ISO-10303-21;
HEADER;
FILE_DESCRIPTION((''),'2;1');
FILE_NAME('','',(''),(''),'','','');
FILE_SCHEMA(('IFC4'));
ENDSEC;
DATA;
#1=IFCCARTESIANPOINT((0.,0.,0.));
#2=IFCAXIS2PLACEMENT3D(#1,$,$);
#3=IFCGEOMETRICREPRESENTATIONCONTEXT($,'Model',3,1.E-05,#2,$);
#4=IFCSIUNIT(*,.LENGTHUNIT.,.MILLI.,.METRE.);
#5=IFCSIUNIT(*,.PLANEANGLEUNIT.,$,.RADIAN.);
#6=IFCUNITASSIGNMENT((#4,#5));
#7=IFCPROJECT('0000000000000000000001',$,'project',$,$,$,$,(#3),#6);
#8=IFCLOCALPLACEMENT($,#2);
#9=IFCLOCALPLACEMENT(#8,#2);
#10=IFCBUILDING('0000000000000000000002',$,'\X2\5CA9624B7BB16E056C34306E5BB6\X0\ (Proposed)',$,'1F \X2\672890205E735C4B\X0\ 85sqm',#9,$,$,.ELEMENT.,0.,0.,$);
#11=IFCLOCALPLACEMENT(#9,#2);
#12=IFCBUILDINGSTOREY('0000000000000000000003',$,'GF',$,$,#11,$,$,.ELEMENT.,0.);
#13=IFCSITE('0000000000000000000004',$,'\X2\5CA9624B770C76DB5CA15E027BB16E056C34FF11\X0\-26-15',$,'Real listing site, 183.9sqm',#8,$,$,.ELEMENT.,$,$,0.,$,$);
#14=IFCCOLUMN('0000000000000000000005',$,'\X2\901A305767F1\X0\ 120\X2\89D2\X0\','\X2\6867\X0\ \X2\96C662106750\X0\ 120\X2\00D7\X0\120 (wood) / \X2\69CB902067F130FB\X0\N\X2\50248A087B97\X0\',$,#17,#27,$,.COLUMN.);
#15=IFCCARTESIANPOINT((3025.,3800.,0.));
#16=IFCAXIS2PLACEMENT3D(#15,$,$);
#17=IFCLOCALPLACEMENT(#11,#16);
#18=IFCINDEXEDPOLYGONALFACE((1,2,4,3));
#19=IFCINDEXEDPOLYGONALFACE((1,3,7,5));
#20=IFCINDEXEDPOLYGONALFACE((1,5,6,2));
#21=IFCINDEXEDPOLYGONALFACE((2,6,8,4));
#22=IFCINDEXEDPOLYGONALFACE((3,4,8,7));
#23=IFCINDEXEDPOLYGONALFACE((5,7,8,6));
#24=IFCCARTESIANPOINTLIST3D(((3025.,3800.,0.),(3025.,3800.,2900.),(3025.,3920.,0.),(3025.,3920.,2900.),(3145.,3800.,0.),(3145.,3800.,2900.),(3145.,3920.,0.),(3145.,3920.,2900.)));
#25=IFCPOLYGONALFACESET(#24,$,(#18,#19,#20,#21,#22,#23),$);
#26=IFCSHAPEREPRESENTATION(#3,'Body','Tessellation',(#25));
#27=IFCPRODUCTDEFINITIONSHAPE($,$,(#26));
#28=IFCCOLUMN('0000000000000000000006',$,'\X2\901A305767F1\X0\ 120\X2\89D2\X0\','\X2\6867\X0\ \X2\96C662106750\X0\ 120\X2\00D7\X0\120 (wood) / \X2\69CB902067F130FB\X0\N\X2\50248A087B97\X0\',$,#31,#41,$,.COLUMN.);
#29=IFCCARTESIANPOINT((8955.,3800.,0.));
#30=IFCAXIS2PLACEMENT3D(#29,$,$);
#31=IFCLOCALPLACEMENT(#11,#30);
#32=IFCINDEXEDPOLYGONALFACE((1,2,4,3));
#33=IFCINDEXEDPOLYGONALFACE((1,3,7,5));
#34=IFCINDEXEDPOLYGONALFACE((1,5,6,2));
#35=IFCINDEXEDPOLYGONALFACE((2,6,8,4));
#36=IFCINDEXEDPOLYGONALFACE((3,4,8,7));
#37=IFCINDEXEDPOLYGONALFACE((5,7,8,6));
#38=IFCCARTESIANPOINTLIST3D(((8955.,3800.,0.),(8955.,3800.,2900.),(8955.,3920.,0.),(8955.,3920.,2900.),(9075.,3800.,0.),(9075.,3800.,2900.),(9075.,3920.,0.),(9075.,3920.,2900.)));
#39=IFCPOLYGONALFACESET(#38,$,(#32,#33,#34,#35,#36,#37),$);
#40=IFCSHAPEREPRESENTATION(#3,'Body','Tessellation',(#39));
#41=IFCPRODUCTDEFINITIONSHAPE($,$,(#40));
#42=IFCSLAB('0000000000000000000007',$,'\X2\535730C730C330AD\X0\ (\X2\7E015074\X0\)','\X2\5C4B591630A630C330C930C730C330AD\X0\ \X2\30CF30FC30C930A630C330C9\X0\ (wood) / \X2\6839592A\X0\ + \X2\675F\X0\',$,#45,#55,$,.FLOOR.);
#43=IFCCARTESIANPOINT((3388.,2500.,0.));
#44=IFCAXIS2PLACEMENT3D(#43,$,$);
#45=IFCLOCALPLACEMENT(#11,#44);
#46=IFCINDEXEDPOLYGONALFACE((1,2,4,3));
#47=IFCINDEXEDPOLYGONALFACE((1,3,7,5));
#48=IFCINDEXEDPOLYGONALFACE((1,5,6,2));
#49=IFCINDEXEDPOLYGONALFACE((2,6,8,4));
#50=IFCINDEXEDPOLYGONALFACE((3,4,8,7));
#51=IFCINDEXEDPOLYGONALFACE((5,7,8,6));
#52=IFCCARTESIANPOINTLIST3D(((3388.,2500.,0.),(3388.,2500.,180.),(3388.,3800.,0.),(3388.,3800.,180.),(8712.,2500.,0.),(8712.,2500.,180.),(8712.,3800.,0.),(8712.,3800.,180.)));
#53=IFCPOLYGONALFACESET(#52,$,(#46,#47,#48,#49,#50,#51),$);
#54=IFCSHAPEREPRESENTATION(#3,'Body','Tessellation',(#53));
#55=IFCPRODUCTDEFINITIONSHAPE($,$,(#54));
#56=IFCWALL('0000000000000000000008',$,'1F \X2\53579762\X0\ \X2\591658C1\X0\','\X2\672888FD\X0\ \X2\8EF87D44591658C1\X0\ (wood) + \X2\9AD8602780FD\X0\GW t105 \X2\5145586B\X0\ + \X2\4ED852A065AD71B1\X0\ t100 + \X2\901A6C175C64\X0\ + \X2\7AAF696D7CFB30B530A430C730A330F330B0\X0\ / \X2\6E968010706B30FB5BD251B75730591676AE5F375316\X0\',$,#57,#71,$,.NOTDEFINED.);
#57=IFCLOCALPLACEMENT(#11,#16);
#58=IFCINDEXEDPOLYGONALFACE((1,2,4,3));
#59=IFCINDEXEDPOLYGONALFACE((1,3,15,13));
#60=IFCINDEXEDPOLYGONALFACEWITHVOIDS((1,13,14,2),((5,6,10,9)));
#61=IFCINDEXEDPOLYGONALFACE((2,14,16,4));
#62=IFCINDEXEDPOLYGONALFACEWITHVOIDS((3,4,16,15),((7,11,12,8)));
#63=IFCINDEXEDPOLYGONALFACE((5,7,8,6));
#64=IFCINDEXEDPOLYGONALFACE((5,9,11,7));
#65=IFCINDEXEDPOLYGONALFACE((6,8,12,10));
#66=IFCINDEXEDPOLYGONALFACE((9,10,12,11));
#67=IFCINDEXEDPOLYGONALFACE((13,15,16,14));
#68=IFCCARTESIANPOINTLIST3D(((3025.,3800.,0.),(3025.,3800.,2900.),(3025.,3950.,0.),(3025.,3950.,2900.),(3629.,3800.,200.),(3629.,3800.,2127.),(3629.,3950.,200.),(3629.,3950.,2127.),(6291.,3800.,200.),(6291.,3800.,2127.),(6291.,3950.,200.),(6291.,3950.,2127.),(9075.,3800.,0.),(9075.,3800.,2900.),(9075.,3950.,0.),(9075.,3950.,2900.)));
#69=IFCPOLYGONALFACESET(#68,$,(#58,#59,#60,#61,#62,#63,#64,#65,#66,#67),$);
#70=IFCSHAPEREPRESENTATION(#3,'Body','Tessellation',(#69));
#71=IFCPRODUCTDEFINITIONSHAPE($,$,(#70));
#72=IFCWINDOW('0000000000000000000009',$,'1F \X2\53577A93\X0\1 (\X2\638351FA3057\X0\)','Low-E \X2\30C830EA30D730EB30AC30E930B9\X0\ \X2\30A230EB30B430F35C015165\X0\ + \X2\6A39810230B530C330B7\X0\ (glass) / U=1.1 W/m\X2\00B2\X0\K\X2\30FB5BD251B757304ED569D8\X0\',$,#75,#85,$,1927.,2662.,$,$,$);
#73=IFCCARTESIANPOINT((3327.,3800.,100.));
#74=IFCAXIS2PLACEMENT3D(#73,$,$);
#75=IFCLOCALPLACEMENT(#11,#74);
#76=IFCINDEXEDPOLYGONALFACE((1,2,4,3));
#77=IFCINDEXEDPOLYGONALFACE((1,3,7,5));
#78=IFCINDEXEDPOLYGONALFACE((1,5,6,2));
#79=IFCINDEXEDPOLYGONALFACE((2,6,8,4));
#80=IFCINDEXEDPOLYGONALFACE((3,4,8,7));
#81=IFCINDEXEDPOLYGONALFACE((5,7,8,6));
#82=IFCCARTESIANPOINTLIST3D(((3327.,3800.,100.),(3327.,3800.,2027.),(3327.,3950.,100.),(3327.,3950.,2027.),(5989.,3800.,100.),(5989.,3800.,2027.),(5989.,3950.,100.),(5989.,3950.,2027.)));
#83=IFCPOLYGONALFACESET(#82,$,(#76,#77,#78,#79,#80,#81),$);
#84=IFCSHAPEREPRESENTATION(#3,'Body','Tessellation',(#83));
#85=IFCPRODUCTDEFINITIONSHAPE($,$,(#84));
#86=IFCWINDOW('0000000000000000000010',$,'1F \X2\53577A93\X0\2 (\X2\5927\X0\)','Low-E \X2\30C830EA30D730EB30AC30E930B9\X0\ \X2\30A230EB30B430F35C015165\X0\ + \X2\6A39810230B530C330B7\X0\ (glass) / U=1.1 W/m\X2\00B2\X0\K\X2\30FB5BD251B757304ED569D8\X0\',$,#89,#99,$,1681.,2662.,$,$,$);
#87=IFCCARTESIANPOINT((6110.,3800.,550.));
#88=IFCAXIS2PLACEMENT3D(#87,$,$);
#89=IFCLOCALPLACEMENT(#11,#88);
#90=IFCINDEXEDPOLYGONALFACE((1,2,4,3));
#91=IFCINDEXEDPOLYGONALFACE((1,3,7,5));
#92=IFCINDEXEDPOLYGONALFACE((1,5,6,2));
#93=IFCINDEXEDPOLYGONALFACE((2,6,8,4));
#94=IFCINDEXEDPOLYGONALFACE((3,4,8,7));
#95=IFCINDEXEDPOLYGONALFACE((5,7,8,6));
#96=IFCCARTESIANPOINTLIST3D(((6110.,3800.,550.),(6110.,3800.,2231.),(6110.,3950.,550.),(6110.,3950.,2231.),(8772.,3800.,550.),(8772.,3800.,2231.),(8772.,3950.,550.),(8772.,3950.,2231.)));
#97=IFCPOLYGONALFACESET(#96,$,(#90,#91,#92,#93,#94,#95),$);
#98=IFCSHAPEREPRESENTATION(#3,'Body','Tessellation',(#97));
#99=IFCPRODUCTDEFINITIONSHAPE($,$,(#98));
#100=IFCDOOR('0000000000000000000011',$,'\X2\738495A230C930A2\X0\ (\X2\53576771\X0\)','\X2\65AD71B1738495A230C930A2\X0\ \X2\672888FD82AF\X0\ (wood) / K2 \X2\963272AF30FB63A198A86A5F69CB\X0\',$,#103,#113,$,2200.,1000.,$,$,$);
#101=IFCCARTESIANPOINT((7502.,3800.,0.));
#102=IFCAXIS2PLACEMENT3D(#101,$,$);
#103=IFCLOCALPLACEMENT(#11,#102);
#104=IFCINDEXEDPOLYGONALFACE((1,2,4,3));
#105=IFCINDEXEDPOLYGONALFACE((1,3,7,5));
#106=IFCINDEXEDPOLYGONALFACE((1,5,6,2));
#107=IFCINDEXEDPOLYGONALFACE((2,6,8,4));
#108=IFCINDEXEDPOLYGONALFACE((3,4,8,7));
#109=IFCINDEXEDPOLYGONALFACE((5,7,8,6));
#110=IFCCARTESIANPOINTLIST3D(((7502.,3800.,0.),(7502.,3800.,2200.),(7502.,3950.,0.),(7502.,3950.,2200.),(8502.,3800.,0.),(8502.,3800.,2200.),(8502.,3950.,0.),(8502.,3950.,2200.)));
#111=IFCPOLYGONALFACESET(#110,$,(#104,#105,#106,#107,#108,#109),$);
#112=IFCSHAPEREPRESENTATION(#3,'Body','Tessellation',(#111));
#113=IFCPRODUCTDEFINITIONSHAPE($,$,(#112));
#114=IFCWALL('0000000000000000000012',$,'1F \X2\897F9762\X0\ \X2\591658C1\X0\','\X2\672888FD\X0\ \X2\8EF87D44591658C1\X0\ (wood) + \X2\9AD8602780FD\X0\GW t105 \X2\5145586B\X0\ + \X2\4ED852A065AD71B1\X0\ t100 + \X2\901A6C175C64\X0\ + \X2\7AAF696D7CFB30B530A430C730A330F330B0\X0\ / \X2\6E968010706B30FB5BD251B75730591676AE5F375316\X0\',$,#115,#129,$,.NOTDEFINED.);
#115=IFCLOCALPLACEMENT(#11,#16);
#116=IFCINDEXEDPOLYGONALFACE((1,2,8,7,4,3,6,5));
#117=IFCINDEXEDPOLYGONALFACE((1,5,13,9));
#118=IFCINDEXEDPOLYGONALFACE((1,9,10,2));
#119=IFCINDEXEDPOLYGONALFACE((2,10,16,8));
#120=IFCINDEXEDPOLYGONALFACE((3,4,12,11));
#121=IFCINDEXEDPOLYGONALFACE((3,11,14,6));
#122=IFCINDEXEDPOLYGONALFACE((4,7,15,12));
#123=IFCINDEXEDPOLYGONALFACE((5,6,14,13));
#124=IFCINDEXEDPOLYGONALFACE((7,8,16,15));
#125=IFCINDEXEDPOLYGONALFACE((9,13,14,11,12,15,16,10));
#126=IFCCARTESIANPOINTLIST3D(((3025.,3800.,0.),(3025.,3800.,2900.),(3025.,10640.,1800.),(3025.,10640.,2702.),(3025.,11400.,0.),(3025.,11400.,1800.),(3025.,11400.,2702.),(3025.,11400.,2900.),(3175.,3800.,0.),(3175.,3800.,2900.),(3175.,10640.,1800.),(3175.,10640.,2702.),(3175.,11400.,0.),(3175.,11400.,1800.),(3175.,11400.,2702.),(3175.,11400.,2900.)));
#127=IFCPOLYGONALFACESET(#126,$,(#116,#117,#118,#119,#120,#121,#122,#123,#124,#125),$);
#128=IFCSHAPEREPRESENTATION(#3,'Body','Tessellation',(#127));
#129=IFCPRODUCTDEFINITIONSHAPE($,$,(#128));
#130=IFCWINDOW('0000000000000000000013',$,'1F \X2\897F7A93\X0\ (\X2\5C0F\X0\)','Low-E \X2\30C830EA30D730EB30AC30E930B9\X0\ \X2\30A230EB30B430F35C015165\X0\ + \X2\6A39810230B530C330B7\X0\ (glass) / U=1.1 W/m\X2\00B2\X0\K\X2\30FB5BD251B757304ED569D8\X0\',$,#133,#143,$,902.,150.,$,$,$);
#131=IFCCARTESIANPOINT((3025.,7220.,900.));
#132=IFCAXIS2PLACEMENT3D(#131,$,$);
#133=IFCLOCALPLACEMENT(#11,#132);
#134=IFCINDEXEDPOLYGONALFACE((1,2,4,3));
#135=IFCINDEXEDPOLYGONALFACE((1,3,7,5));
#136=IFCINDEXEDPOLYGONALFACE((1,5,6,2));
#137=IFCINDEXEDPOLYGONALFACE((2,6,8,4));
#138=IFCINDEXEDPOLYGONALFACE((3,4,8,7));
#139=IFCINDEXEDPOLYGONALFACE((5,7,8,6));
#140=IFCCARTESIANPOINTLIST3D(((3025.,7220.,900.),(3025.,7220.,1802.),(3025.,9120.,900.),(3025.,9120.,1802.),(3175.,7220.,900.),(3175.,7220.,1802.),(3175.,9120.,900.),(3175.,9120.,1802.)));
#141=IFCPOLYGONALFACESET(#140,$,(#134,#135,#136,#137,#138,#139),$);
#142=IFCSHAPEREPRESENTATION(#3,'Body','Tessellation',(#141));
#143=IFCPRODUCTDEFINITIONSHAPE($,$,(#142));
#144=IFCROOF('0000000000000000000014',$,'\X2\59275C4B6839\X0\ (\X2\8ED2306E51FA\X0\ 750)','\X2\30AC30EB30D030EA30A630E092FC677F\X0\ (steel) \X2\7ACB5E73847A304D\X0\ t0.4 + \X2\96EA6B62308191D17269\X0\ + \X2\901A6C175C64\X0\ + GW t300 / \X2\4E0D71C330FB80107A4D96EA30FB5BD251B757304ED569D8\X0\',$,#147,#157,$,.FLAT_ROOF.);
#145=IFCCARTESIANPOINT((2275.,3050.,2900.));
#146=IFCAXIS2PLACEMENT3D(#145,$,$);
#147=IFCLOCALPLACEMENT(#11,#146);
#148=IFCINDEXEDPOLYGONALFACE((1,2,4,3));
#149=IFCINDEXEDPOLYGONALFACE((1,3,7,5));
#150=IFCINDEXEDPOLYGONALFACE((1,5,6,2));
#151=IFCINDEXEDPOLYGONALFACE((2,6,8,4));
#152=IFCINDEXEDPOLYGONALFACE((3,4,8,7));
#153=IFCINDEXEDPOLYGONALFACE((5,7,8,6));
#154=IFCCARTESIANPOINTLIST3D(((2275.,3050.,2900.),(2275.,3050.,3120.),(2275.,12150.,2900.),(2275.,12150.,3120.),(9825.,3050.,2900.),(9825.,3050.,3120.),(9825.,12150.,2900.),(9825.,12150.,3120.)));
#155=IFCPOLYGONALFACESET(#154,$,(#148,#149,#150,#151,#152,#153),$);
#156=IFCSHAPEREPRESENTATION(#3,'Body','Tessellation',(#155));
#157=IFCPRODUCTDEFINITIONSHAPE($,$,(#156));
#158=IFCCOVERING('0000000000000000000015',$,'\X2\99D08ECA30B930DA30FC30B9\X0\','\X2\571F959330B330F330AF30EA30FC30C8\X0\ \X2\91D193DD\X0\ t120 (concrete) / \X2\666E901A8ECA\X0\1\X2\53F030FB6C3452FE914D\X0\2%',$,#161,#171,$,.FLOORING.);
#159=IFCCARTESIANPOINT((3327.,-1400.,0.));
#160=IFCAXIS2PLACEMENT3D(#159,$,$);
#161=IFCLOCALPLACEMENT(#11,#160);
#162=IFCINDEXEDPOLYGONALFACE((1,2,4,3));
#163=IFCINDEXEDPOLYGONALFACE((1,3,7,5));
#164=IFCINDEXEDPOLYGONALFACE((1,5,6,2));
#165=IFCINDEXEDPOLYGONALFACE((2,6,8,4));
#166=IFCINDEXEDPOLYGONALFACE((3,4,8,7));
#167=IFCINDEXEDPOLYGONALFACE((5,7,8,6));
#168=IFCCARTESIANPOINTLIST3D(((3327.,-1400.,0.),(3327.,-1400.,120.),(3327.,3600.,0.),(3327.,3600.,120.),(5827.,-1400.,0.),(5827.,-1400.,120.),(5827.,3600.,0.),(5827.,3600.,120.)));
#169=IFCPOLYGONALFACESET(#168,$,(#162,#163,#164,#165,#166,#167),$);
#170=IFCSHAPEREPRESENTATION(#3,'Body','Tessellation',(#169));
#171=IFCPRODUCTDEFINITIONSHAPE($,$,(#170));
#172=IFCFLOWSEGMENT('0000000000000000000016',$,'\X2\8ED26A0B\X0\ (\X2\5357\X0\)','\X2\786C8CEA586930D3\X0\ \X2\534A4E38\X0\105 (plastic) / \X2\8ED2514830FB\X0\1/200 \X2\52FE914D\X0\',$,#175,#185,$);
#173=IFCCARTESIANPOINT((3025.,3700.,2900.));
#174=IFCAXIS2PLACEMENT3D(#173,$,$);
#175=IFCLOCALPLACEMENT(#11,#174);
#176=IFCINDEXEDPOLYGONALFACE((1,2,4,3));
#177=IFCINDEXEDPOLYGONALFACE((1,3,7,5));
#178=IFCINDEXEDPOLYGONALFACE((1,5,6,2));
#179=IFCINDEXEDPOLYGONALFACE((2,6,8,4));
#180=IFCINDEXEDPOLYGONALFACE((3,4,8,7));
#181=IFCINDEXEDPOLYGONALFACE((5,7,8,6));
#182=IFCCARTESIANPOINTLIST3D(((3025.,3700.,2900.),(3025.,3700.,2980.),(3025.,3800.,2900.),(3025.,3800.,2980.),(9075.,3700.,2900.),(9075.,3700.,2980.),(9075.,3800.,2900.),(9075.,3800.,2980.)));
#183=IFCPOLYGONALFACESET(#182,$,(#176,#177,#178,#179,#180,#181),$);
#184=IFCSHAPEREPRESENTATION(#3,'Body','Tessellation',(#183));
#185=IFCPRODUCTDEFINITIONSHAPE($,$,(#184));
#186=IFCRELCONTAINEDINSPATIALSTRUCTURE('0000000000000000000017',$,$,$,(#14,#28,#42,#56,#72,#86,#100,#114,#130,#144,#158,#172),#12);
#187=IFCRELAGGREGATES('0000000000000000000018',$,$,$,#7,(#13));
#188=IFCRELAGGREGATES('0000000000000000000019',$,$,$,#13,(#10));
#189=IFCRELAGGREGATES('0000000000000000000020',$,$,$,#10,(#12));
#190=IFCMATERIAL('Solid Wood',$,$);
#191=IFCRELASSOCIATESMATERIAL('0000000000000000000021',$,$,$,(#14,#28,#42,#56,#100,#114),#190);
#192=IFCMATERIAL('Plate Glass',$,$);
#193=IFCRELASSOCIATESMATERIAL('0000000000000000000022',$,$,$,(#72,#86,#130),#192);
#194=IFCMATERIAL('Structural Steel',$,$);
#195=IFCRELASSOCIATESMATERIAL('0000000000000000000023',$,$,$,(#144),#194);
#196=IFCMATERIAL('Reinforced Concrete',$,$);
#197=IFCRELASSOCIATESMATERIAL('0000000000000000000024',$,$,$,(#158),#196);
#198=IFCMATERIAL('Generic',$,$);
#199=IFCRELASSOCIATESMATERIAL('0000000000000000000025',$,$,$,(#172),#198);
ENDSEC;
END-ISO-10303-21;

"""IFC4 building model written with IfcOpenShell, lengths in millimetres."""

from ifc_helpers import new_model, si_unit, frame, frame_2d, origin, place, context, project, spatial, rectangle, extrude, material, element, fill, save


model = new_model("IFC4")

# Units and contexts
model_context = context("Model", 3, precision=1e-05, world=origin())
ifc_project = project(units=[si_unit("LENGTHUNIT", "METRE", prefix="MILLI"), si_unit("PLANEANGLEUNIT", "RADIAN")], contexts=[model_context])

# Site, building, storey
site_placement = place(None, origin())
site = spatial("IfcSite", under=ifc_project, at=site_placement, Name="岩手県盛岡市箱清水１-26-15", ObjectType="Real listing site, 183.9sqm", CompositionType="ELEMENT", RefElevation=0.0)
building_placement = place(site_placement, origin())
building = spatial("IfcBuilding", under=site, at=building_placement, Name="岩手箱清水の家 (Proposed)", ObjectType="1F 木造平屋 85sqm", CompositionType="ELEMENT", ElevationOfRefHeight=0.0, ElevationOfTerrain=0.0)
storey_placement = place(building_placement, origin())
storey = spatial("IfcBuildingStorey", under=building, at=storey_placement, Name="GF", CompositionType="ELEMENT", Elevation=0.0)

# Columns
ifc_material_1 = material(Name="Solid Wood")
column_1_placement = place(storey_placement, frame((3025.0, 3800.0, 0.0)))
element("IfcColumn", 1, at=column_1_placement, inside=storey, material=ifc_material_1, Name="通し柱 120角", Description="桧 集成材 120×120 (wood) / 構造柱・N値計算", PredefinedType="COLUMN", context=model_context, shape_type="SweptSolid", body=[
    extrude(rectangle(XDim=120.0, YDim=120.0, at=frame_2d((60.0, 60.0))), frame((3025.0, 3800.0, 0.0)), (0.0, 0.0, 1.0), 2900.0),
])
column_2_placement = place(storey_placement, frame((8955.0, 3800.0, 0.0)))
element("IfcColumn", 2, at=column_2_placement, inside=storey, material=ifc_material_1, Name="通し柱 120角", Description="桧 集成材 120×120 (wood) / 構造柱・N値計算", PredefinedType="COLUMN", context=model_context, shape_type="SweptSolid", body=[
    extrude(rectangle(XDim=120.0, YDim=120.0, at=frame_2d((60.0, 60.0))), frame((8955.0, 3800.0, 0.0)), (0.0, 0.0, 1.0), 2900.0),
])

# Slab
ifc_material_2 = material(Name="Reinforced Concrete")
slab_1_placement = place(storey_placement, frame((3388.0, 2500.0, 0.0)))
element("IfcSlab", 3, at=slab_1_placement, inside=storey, material=ifc_material_1, Name="南デッキ (縁側)", Description="屋外ウッドデッキ ハードウッド (wood) / 根太 + 束", PredefinedType="FLOOR", context=model_context, shape_type="SweptSolid", body=[
    extrude(rectangle(XDim=5324.0, YDim=1300.0, at=frame_2d((2662.0, 650.0))), frame((3388.0, 2500.0, 0.0)), (0.0, 0.0, 1.0), 180.0),
])

# Wall, openings, windows, door
wall_1_placement = place(storey_placement, frame((3025.0, 3800.0, 0.0)))
wall_1 = element("IfcWall", 4, at=wall_1_placement, inside=storey, material=ifc_material_1, Name="1F 南面 外壁", Description="木製 軸組外壁 (wood) + 高性能GW t105 充填 + 付加断熱 t100 + 通気層 + 窯業系サイディング / 準耐火・寒冷地外皮強化", PredefinedType="NOTDEFINED", context=model_context, shape_type="SweptSolid", body=[
    extrude(rectangle(XDim=6050.0, YDim=150.0, at=frame_2d((3025.0, 75.0))), frame((3025.0, 3800.0, 0.0)), (0.0, 0.0, 1.0), 2900.0),
])
opening_1_placement = place(storey_placement, frame((3327.0, 3800.0, 100.0)))
opening_1 = element("IfcOpeningElement", 5, at=opening_1_placement, cuts=wall_1, PredefinedType="NOTDEFINED", context=model_context, shape_type="SweptSolid", body=[
    extrude(rectangle(XDim=2662.0, YDim=150.0, at=frame_2d((1331.0, 75.0))), frame((3327.0, 3800.0, 100.0)), (0.0, 0.0, 1.0), 1927.0),
])
opening_2_placement = place(storey_placement, frame((6110.0, 3800.0, 550.0)))
opening_2 = element("IfcOpeningElement", 6, at=opening_2_placement, cuts=wall_1, PredefinedType="NOTDEFINED", context=model_context, shape_type="SweptSolid", body=[
    extrude(rectangle(XDim=2662.0, YDim=150.0, at=frame_2d((1331.0, 75.0))), frame((6110.0, 3800.0, 550.0)), (0.0, 0.0, 1.0), 1681.0),
])
opening_3_placement = place(storey_placement, frame((7502.0, 3800.0, 0.0)))
opening_3 = element("IfcOpeningElement", 7, at=opening_3_placement, cuts=wall_1, PredefinedType="NOTDEFINED", context=model_context, shape_type="SweptSolid", body=[
    extrude(rectangle(XDim=1000.0, YDim=150.0, at=frame_2d((500.0, 75.0))), frame((7502.0, 3800.0, 0.0)), (0.0, 0.0, 1.0), 2200.0),
])
ifc_material_3 = material(Name="Plate Glass")
window_1_placement = place(storey_placement, frame((3327.0, 3800.0, 100.0)))
window_1 = element("IfcWindow", 8, at=window_1_placement, inside=storey, material=ifc_material_3, Name="1F 南窓1 (掃出し)", Description="Low-E トリプルガラス アルゴン封入 + 樹脂サッシ (glass) / U=1.1 W/m²K・寒冷地仕様", OverallHeight=1927.0, OverallWidth=2662.0, context=model_context, shape_type="SweptSolid", body=[
    extrude(rectangle(XDim=2662.0, YDim=150.0, at=frame_2d((1331.0, 75.0))), frame((3327.0, 3800.0, 100.0)), (0.0, 0.0, 1.0), 1927.0),
])
fill(opening_1, window_1)
window_2_placement = place(storey_placement, frame((6110.0, 3800.0, 550.0)))
window_2 = element("IfcWindow", 9, at=window_2_placement, inside=storey, material=ifc_material_3, Name="1F 南窓2 (大)", Description="Low-E トリプルガラス アルゴン封入 + 樹脂サッシ (glass) / U=1.1 W/m²K・寒冷地仕様", OverallHeight=1681.0, OverallWidth=2662.0, context=model_context, shape_type="SweptSolid", body=[
    extrude(rectangle(XDim=2662.0, YDim=150.0, at=frame_2d((1331.0, 75.0))), frame((6110.0, 3800.0, 550.0)), (0.0, 0.0, 1.0), 1681.0),
])
fill(opening_2, window_2)
door_placement = place(storey_placement, frame((7502.0, 3800.0, 0.0)))
door = element("IfcDoor", 10, at=door_placement, inside=storey, material=ifc_material_1, Name="玄関ドア (南東)", Description="断熱玄関ドア 木製芯 (wood) / K2 防犯・採風機構", OverallHeight=2200.0, OverallWidth=1000.0, context=model_context, shape_type="SweptSolid", body=[
    extrude(rectangle(XDim=1000.0, YDim=150.0, at=frame_2d((500.0, 75.0))), frame((7502.0, 3800.0, 0.0)), (0.0, 0.0, 1.0), 2200.0),
])
fill(opening_3, door)

# Wall, opening, window
wall_2_placement = place(storey_placement, frame((3025.0, 3800.0, 0.0)))
wall_2 = element("IfcWall", 11, at=wall_2_placement, inside=storey, material=ifc_material_1, Name="1F 西面 外壁", Description="木製 軸組外壁 (wood) + 高性能GW t105 充填 + 付加断熱 t100 + 通気層 + 窯業系サイディング / 準耐火・寒冷地外皮強化", PredefinedType="NOTDEFINED", context=model_context, shape_type="SweptSolid", body=[
    extrude(rectangle(XDim=150.0, YDim=7600.0, at=frame_2d((75.0, 3800.0))), frame((3025.0, 3800.0, 0.0)), (0.0, 0.0, 1.0), 2900.0),
])
opening_4_placement = place(storey_placement, frame((3025.0, 7220.0, 900.0)))
opening_4 = element("IfcOpeningElement", 12, at=opening_4_placement, cuts=wall_2, PredefinedType="NOTDEFINED", context=model_context, shape_type="SweptSolid", body=[
    extrude(rectangle(XDim=150.0, YDim=1900.0, at=frame_2d((75.0, 950.0))), frame((3025.0, 7220.0, 900.0)), (0.0, 0.0, 1.0), 902.0),
])
window_3_placement = place(storey_placement, frame((3025.0, 7220.0, 900.0)))
window_3 = element("IfcWindow", 13, at=window_3_placement, inside=storey, material=ifc_material_3, Name="1F 西窓 (小)", Description="Low-E トリプルガラス アルゴン封入 + 樹脂サッシ (glass) / U=1.1 W/m²K・寒冷地仕様", OverallHeight=902.0, OverallWidth=150.0, context=model_context, shape_type="SweptSolid", body=[
    extrude(rectangle(XDim=150.0, YDim=1900.0, at=frame_2d((75.0, 950.0))), frame((3025.0, 7220.0, 900.0)), (0.0, 0.0, 1.0), 902.0),
])
fill(opening_4, window_3)

# Roof
ifc_material_4 = material(Name="Structural Steel")
roof_placement = place(storey_placement, frame((2275.0, 3050.0, 2900.0)))
element("IfcRoof", 14, at=roof_placement, inside=storey, material=ifc_material_4, Name="大屋根 (軒の出 750)", Description="ガルバリウム鋼板 (steel) 立平葺き t0.4 + 雪止め金物 + 通気層 + GW t300 / 不燃・耐積雪・寒冷地仕様", PredefinedType="FLAT_ROOF", context=model_context, shape_type="SweptSolid", body=[
    extrude(rectangle(XDim=7550.0, YDim=9100.0, at=frame_2d((3775.0, 4550.0))), frame((2275.0, 3050.0, 2900.0)), (0.0, 0.0, 1.0), 220.0),
])

# Covering
covering_1_placement = place(storey_placement, frame((3327.0, -1400.0, 0.0)))
element("IfcCovering", 15, at=covering_1_placement, inside=storey, material=ifc_material_2, Name="駐車スペース", Description="土間コンクリート 金鏝 t120 (concrete) / 普通車1台・水勾配2%", PredefinedType="FLOORING", context=model_context, shape_type="SweptSolid", body=[
    extrude(rectangle(XDim=2500.0, YDim=5000.0, at=frame_2d((1250.0, 2500.0))), frame((3327.0, -1400.0, 0.0)), (0.0, 0.0, 1.0), 120.0),
])

# Flow segment
ifc_material_5 = material(Name="Generic")
flow_segment_1_placement = place(storey_placement, frame((3025.0, 3700.0, 2900.0)))
element("IfcFlowSegment", 16, at=flow_segment_1_placement, inside=storey, material=ifc_material_5, Name="軒樋 (南)", Description="硬質塩ビ 半丸105 (plastic) / 軒先・1/200 勾配", context=model_context, shape_type="SweptSolid", body=[
    extrude(rectangle(XDim=6050.0, YDim=100.0, at=frame_2d((3025.0, 50.0))), frame((3025.0, 3700.0, 2900.0)), (0.0, 0.0, 1.0), 80.0),
])

save(model, "model.ifc")
